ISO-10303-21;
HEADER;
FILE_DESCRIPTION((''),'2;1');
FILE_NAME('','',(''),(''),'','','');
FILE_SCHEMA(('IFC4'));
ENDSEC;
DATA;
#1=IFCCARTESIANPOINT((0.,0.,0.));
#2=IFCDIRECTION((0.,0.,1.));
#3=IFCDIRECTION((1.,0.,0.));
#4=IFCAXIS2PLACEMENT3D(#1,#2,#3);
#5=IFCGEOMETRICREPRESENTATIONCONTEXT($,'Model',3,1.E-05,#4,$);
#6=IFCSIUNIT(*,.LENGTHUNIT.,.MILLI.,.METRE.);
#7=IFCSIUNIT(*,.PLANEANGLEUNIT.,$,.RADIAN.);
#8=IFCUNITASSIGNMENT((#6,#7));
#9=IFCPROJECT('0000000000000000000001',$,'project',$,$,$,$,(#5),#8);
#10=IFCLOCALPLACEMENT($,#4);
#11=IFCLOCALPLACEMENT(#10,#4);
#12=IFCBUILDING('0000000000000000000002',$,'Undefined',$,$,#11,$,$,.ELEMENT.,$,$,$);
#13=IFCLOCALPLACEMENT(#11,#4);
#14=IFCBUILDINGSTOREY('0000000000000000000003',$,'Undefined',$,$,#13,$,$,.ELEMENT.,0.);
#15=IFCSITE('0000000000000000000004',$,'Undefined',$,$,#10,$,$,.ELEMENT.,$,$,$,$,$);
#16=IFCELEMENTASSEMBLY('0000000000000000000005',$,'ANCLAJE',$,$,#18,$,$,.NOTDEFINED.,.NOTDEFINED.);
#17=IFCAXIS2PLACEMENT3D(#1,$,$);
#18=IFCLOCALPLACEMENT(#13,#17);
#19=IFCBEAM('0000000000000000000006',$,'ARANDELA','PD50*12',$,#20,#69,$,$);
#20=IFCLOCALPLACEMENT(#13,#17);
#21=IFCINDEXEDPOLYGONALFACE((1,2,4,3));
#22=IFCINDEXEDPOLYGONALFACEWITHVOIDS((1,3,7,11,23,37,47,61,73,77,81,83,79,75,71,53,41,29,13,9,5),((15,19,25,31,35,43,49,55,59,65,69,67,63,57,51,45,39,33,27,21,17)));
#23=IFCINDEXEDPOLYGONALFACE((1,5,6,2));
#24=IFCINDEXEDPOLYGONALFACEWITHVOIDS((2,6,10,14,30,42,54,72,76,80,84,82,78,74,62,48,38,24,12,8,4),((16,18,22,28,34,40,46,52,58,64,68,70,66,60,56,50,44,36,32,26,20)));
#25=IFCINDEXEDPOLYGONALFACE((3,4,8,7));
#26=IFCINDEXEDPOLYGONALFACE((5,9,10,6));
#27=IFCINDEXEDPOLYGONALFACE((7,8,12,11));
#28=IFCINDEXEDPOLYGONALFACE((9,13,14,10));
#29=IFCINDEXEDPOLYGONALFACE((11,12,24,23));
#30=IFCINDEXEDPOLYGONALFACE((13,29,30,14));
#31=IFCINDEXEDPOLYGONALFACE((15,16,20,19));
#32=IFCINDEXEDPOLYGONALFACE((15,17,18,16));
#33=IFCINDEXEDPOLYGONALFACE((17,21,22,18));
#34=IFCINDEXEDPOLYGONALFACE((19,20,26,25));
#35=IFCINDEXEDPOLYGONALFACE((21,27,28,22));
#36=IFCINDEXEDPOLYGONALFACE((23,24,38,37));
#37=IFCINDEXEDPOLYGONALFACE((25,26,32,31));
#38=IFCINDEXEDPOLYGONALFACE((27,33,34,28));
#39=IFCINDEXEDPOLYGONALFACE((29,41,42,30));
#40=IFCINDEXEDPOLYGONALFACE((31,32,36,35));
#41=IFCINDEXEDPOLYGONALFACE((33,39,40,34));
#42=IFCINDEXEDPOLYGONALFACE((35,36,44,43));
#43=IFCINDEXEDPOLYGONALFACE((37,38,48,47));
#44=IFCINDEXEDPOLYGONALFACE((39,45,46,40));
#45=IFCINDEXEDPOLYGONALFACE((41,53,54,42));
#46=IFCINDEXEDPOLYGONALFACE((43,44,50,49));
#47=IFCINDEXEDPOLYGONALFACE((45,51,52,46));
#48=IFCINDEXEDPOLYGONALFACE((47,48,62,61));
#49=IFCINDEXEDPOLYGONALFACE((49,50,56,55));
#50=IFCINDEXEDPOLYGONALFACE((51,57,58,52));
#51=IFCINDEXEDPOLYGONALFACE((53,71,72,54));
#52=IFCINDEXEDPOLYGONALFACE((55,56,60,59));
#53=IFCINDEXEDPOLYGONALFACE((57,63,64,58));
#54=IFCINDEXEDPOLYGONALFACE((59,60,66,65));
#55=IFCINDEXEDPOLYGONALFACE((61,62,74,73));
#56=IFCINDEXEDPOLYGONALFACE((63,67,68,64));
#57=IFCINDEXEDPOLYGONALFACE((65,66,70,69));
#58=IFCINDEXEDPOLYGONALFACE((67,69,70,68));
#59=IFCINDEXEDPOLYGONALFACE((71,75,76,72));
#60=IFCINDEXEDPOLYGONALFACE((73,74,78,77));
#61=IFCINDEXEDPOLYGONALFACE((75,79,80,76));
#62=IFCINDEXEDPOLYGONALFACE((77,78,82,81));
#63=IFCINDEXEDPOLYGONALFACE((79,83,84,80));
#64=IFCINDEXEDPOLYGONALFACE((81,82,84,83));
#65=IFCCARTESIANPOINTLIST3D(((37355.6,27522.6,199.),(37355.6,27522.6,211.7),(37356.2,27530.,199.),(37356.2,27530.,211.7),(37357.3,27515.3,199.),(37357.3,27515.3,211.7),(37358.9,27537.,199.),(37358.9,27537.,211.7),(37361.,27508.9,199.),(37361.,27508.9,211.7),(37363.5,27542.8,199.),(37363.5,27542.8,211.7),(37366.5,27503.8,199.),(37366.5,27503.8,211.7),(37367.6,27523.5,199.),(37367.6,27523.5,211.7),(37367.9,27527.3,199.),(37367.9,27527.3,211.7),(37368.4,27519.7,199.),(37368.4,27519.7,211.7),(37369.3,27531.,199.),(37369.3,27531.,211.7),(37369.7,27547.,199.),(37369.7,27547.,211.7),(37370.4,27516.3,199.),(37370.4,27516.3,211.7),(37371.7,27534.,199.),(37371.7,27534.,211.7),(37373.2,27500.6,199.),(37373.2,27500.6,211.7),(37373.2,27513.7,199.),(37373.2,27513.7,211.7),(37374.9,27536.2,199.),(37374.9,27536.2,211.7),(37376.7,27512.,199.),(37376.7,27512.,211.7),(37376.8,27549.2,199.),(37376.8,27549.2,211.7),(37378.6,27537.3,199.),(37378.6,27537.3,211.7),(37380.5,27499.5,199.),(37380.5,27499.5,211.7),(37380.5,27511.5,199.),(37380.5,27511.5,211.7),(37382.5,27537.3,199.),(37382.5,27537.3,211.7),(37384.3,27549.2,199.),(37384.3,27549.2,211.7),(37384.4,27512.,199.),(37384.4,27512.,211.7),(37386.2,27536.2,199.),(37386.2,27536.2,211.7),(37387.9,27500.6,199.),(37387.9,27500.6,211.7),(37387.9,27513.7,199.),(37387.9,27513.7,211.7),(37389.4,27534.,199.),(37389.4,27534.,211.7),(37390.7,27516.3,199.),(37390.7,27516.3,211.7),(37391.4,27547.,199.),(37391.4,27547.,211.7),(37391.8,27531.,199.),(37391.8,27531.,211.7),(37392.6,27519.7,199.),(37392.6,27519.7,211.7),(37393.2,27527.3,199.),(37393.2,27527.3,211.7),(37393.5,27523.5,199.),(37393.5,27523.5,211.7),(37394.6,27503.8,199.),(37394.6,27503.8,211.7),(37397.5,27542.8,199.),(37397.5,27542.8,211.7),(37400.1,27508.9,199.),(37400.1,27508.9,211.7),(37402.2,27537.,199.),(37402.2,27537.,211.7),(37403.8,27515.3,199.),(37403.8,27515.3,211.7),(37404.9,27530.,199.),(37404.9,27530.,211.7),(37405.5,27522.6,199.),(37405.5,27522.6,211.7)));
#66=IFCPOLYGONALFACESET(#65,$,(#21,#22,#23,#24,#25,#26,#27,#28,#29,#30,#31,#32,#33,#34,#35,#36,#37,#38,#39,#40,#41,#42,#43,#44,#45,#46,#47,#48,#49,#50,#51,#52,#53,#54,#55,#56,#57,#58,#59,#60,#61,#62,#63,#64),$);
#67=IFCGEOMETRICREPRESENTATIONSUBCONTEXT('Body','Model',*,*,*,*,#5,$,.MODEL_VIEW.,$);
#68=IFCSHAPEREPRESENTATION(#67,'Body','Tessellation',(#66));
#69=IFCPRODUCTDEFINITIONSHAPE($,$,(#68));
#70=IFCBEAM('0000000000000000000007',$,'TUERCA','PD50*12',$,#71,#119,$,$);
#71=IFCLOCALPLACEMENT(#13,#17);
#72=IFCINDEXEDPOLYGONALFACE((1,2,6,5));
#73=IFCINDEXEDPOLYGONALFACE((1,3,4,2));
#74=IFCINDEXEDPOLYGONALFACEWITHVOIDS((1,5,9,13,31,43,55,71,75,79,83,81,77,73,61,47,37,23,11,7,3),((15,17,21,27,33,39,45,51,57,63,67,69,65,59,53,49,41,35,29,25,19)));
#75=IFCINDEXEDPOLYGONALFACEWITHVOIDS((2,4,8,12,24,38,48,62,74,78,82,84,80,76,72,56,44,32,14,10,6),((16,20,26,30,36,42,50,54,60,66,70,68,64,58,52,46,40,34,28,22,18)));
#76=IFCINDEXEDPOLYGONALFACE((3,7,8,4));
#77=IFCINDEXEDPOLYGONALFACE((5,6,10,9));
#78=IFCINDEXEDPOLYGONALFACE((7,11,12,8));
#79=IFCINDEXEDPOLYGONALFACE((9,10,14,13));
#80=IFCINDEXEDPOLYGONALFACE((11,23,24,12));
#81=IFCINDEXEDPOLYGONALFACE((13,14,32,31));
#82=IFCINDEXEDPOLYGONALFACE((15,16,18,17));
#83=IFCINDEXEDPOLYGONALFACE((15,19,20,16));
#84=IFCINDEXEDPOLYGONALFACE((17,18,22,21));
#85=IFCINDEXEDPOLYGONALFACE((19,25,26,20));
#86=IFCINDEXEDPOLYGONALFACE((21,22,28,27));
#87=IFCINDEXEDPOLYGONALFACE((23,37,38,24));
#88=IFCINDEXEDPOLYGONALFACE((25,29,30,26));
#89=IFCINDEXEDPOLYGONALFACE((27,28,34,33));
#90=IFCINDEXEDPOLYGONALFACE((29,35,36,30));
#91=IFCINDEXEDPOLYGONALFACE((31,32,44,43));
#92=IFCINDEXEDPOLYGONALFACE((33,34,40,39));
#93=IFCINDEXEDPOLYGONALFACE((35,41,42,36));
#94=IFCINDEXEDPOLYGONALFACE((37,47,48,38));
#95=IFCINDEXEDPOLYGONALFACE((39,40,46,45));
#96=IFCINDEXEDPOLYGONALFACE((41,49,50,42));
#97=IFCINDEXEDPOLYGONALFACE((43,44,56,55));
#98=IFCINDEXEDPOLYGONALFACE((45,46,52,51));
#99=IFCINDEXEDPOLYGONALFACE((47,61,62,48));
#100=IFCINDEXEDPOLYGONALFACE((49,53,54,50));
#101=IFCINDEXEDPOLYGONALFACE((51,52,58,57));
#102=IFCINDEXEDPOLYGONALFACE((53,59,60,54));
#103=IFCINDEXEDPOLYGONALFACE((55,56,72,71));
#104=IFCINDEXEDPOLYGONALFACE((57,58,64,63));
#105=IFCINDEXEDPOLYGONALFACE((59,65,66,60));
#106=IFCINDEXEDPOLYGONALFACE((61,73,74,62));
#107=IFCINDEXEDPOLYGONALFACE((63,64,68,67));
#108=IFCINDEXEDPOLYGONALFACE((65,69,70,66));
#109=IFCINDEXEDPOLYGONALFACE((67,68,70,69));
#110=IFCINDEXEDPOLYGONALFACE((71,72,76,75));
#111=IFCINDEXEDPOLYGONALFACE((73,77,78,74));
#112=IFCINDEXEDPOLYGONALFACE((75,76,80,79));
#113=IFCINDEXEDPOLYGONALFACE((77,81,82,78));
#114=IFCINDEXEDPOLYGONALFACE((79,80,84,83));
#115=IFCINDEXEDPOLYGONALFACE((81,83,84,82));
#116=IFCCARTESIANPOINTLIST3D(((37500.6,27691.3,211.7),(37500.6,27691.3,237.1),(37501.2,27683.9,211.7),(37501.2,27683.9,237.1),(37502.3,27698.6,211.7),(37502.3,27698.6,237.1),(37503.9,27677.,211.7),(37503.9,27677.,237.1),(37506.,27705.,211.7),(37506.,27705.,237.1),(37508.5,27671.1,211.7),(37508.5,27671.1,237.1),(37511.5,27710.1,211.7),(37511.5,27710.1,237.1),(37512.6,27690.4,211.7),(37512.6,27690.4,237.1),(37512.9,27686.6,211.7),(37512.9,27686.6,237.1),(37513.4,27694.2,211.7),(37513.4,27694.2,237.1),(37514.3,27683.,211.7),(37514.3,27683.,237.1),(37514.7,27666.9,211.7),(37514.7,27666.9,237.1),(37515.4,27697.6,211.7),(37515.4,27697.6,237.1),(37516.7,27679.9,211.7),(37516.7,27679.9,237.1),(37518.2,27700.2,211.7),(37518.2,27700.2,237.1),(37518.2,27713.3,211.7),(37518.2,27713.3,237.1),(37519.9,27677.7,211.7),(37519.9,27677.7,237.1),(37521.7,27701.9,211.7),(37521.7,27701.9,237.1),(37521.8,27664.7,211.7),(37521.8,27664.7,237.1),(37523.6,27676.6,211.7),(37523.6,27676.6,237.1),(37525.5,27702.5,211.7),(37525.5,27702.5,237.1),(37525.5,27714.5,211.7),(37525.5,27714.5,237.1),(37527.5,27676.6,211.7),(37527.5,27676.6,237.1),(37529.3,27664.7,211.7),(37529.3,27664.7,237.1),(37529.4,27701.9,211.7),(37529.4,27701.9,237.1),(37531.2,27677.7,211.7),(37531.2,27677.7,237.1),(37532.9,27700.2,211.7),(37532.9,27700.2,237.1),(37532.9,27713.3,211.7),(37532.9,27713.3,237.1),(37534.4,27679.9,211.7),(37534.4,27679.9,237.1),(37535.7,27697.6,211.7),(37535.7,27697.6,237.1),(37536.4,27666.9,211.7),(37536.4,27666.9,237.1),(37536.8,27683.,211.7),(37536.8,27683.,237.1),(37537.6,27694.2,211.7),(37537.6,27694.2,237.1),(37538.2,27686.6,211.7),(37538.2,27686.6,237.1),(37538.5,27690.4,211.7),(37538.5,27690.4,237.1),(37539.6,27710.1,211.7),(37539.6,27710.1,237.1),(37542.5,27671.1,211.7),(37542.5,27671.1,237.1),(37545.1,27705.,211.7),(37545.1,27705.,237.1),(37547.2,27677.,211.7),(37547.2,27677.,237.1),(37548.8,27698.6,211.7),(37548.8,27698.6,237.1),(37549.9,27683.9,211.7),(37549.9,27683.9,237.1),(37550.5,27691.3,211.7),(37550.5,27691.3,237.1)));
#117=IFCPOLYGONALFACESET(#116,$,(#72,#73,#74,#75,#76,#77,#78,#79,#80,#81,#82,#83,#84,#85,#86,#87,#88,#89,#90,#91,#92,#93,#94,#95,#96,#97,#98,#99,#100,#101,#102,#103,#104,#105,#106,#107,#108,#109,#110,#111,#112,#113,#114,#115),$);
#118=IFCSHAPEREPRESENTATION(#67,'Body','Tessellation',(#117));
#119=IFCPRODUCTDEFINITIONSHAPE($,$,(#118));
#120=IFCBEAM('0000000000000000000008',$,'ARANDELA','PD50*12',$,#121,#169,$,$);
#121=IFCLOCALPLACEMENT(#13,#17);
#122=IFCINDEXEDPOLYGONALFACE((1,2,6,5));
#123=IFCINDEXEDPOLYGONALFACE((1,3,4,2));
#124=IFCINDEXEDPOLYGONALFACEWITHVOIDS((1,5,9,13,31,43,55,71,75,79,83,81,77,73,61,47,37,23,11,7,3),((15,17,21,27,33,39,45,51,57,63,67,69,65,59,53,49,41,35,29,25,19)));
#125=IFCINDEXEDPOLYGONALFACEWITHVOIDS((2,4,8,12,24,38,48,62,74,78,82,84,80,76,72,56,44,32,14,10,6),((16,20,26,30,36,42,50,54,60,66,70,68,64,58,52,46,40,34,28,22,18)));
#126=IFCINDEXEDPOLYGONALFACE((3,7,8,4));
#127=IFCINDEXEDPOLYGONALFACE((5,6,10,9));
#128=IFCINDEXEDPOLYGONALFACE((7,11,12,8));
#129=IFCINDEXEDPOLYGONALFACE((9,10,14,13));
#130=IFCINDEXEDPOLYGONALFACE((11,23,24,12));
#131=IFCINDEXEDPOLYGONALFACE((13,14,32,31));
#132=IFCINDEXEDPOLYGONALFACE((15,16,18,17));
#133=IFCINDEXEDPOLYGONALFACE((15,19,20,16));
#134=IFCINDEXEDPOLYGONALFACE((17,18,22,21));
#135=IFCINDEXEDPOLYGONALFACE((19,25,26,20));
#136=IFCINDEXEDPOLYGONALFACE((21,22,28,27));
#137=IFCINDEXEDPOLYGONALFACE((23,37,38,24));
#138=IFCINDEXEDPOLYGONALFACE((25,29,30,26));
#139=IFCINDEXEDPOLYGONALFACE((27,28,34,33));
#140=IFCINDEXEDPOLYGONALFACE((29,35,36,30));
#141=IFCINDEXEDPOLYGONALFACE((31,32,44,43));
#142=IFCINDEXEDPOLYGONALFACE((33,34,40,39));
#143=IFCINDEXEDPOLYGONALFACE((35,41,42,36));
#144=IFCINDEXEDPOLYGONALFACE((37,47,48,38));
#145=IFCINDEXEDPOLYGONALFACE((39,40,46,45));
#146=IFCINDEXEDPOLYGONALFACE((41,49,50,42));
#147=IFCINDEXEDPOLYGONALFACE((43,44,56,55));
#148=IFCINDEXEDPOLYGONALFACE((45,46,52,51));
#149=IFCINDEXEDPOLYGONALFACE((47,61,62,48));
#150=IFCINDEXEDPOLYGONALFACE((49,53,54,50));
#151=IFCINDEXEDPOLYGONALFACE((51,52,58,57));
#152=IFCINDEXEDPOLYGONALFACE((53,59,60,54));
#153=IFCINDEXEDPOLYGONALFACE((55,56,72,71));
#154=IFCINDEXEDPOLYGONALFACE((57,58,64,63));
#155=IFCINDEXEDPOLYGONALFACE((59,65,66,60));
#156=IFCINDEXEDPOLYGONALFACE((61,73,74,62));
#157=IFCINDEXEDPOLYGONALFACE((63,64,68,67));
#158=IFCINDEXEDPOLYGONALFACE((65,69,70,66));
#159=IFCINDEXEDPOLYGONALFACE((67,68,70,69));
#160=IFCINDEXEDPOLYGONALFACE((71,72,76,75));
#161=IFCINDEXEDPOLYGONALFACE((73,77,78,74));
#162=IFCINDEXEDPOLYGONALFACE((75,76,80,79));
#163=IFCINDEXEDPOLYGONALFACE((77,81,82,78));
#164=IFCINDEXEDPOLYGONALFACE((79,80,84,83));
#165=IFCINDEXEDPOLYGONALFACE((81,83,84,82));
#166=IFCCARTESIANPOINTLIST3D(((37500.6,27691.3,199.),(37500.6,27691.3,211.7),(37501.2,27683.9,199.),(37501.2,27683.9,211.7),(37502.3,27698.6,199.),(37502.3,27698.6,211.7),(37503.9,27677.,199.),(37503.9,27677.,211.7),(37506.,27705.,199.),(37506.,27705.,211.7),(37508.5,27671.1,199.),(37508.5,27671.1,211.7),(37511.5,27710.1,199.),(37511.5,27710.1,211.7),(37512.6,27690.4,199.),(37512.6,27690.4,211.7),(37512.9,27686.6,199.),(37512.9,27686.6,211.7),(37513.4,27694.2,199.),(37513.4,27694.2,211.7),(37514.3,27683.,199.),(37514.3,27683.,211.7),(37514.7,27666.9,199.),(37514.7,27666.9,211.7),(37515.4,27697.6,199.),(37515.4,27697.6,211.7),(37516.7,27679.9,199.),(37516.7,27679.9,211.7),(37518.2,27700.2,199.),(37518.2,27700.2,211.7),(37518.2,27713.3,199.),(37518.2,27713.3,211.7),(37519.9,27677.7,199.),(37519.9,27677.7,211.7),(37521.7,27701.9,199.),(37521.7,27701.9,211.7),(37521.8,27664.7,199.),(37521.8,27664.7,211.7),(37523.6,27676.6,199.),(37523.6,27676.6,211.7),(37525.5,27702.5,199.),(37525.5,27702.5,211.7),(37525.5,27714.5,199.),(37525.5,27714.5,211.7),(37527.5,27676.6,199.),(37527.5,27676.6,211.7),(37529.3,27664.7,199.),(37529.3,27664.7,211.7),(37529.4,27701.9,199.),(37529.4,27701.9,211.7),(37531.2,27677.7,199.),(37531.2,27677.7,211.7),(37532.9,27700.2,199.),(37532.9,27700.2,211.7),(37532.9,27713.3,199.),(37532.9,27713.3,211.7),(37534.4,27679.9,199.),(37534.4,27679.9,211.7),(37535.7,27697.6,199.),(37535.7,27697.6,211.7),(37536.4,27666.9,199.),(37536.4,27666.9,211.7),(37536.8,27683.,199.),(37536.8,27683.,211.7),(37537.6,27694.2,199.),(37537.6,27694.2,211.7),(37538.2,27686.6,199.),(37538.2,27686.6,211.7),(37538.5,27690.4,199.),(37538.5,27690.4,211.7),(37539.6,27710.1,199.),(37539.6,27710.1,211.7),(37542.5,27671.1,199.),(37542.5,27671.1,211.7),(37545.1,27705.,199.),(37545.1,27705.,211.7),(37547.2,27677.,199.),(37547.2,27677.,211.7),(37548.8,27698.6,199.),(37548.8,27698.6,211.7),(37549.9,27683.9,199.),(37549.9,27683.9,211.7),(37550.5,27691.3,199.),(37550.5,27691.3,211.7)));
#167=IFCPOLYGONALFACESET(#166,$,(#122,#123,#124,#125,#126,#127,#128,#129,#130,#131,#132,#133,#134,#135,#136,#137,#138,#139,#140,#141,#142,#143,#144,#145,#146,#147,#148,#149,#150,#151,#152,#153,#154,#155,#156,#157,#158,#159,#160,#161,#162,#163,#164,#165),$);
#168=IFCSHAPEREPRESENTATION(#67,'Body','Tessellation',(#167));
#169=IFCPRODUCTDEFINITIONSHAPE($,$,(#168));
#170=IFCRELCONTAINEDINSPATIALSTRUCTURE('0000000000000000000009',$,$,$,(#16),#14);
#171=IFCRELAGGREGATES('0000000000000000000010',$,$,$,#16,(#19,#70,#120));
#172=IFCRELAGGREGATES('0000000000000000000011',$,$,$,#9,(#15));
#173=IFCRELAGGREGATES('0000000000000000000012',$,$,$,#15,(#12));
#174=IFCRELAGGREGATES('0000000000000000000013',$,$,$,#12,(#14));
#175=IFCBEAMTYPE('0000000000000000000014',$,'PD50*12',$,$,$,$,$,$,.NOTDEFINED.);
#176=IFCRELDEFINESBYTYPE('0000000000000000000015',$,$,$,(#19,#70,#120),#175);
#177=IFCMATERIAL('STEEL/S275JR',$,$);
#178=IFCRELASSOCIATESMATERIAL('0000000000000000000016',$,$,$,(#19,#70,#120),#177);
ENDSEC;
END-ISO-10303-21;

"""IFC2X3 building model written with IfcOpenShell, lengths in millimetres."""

from ifc_helpers import new_model, si_unit, frame, origin_with_axes, origin_2d_with_axis, place, context, subcontext, project, spatial, hollow_circle, extrude, material, type_object, element, aggregate, save


model = new_model("IFC2X3")

# Units and contexts
model_context = context("Model", 3, precision=1e-05, world=origin_with_axes())
body_context = subcontext(model_context, "Body", "Model", "MODEL_VIEW")
ifc_project = project(units=[si_unit("LENGTHUNIT", "METRE", prefix="MILLI"), si_unit("PLANEANGLEUNIT", "RADIAN")], contexts=[model_context])

# Site, building, storey
site_placement = place(None, origin_with_axes())
site = spatial("IfcSite", under=ifc_project, at=site_placement, Name="Undefined", CompositionType="ELEMENT")
building_placement = place(site_placement, origin_with_axes())
building = spatial("IfcBuilding", under=site, at=building_placement, Name="Undefined", CompositionType="ELEMENT")
storey_placement = place(building_placement, origin_with_axes())
storey = spatial("IfcBuildingStorey", under=building, at=storey_placement, Name="Undefined", CompositionType="ELEMENT", Elevation=0.0)

# Element assembly, beams
assembly_1_placement = place(storey_placement, origin_with_axes())
assembly_1 = element("IfcElementAssembly", 1, at=assembly_1_placement, inside=storey, Name="ANCLAJE", AssemblyPlace="NOTDEFINED", PredefinedType="NOTDEFINED")
ifc_material_1 = material(Name="STEEL/S275JR")
beam_type_1 = type_object("IfcBeamType", Name="PD50*12", PredefinedType="NOTDEFINED")
beam_1_placement = place(assembly_1_placement, frame((37380.5, 27524.5, 211.7), z_axis=(1.0, 0.0, 0.0), x_axis=(0.0, 0.0, -1.0)))
beam_1 = element("IfcBeam", 2, at=beam_1_placement, type_object=beam_type_1, material=ifc_material_1, Name="ARANDELA", Description="PD50*12", context=body_context, shape_type="SweptSolid", body=[
    extrude(hollow_circle(Radius=25.0, WallThickness=12.0, at=origin_2d_with_axis()), frame((12.7, 0.0, 0.0), z_axis=(-1.0, 0.0, 0.0), x_axis=(0.0, -1.0, 0.0)), (0.0, 0.0, 1.0), 12.7),
])
beam_2_placement = place(assembly_1_placement, frame((37525.5, 27689.5, 237.1), z_axis=(-1.0, 0.0, 0.0), x_axis=(0.0, 0.0, -1.0)))
beam_2 = element("IfcBeam", 3, at=beam_2_placement, type_object=beam_type_1, material=ifc_material_1, Name="TUERCA", Description="PD50*12", context=body_context, shape_type="SweptSolid", body=[
    extrude(hollow_circle(Radius=25.0, WallThickness=12.0, at=origin_2d_with_axis()), frame((25.4, 0.0, 0.0), z_axis=(-1.0, 0.0, 0.0), x_axis=(0.0, -1.0, 0.0)), (0.0, 0.0, 1.0), 25.4),
])
beam_3_placement = place(assembly_1_placement, frame((37525.5, 27689.5, 211.7), z_axis=(-1.0, 0.0, 0.0), x_axis=(0.0, 0.0, -1.0)))
beam_3 = element("IfcBeam", 4, at=beam_3_placement, type_object=beam_type_1, material=ifc_material_1, Name="ARANDELA", Description="PD50*12", context=body_context, shape_type="SweptSolid", body=[
    extrude(hollow_circle(Radius=25.0, WallThickness=12.0, at=origin_2d_with_axis()), frame((12.7, 0.0, 0.0), z_axis=(-1.0, 0.0, 0.0), x_axis=(0.0, -1.0, 0.0)), (0.0, 0.0, 1.0), 12.7),
])

aggregate(assembly_1, [beam_1, beam_2, beam_3])

save(model, "model.ifc")
